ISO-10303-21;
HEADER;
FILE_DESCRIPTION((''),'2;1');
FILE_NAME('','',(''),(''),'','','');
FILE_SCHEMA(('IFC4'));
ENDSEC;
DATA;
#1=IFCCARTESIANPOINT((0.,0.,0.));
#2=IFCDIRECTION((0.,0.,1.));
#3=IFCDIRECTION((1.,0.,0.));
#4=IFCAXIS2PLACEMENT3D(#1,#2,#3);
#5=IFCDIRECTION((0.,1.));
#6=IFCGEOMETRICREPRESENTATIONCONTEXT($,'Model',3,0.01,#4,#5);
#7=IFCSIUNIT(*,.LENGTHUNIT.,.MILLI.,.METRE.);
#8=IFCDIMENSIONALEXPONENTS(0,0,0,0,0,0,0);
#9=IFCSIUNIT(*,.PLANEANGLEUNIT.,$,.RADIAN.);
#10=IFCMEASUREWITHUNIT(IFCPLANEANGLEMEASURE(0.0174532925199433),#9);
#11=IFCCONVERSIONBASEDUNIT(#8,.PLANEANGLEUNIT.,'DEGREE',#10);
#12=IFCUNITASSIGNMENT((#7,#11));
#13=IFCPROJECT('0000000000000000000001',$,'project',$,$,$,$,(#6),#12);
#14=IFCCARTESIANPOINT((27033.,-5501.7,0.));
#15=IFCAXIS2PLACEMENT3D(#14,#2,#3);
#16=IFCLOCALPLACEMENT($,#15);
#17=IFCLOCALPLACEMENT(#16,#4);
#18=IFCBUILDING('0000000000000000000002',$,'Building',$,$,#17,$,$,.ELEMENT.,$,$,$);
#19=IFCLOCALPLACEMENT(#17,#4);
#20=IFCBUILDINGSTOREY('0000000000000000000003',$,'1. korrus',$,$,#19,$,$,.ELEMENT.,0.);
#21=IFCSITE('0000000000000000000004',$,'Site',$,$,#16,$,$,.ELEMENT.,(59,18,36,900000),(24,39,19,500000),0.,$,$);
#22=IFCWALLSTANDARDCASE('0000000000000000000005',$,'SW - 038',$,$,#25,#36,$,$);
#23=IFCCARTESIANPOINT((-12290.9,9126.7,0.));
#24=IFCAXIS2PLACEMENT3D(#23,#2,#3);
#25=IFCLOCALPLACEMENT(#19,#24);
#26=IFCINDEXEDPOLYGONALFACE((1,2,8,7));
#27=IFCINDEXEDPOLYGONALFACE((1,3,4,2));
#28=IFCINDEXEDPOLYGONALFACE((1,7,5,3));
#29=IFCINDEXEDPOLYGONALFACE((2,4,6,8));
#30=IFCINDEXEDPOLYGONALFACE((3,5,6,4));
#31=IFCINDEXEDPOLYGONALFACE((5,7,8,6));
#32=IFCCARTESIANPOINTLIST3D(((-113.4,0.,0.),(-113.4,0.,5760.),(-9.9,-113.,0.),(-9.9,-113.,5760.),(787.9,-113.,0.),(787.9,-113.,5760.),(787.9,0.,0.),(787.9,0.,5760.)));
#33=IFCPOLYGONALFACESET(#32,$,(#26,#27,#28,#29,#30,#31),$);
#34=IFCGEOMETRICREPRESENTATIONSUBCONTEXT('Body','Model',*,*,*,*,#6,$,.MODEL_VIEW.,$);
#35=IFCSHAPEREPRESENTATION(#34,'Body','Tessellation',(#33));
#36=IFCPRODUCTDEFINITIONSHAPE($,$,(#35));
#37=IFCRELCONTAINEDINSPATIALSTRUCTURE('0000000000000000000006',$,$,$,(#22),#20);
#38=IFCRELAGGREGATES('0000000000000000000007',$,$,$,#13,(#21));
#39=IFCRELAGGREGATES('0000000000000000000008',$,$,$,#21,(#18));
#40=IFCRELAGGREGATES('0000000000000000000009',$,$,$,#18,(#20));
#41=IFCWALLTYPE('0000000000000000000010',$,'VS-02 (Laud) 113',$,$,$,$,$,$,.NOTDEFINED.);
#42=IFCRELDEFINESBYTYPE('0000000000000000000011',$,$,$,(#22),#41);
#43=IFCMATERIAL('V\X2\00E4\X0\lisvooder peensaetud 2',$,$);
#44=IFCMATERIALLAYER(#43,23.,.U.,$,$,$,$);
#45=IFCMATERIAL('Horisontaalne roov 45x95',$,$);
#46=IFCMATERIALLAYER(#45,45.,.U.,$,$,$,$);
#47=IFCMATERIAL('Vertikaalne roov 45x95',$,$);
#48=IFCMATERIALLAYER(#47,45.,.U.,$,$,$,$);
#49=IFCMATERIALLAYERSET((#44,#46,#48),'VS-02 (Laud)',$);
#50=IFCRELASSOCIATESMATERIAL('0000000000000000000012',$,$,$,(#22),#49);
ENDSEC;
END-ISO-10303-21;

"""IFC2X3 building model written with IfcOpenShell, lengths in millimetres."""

from ifc_helpers import new_model, entity, si_unit, converted_unit, direction, frame, origin_with_axes, place, context, subcontext, project, spatial, polyline, outline, extrude, material, layer, layer_set, layer_usage, type_object, element, save


model = new_model("IFC2X3")

# Units and contexts
model_context = context("Model", 3, precision=0.01, world=origin_with_axes(), true_north=direction((0.0, 1.0)))
body_context = subcontext(model_context, "Body", "Model", "MODEL_VIEW")
ifc_project = project(units=[si_unit("LENGTHUNIT", "METRE", prefix="MILLI"), converted_unit("PLANEANGLEUNIT", "DEGREE", entity("IfcPlaneAngleMeasure", 0.0174532925199433), si_unit("PLANEANGLEUNIT", "RADIAN"), dimensions=[0, 0, 0, 0, 0, 0, 0])], contexts=[model_context])

# Site, building, storey
site_placement = place(None, frame((27033.0, -5501.7, 0.0), z_axis=(0.0, 0.0, 1.0), x_axis=(1.0, 0.0, 0.0)))
site = spatial("IfcSite", under=ifc_project, at=site_placement, Name="Site", CompositionType="ELEMENT", RefLatitude=(59, 18, 36, 900000), RefLongitude=(24, 39, 19, 500000), RefElevation=0.0)
building_placement = place(site_placement, origin_with_axes())
building = spatial("IfcBuilding", under=site, at=building_placement, Name="Building", CompositionType="ELEMENT")
storey_placement = place(building_placement, origin_with_axes())
storey = spatial("IfcBuildingStorey", under=building, at=storey_placement, Name="1. korrus", CompositionType="ELEMENT", Elevation=0.0)

# Wall
ifc_material_1 = material(Name="Välisvooder peensaetud 2")
ifc_layer_1 = layer(ifc_material_1, 23.0, ventilated="UNKNOWN")
ifc_material_2 = material(Name="Horisontaalne roov 45x95")
ifc_layer_2 = layer(ifc_material_2, 45.0, ventilated="UNKNOWN")
ifc_material_3 = material(Name="Vertikaalne roov 45x95")
ifc_layer_3 = layer(ifc_material_3, 45.0, ventilated="UNKNOWN")
ifc_layer_set_1 = layer_set([ifc_layer_1, ifc_layer_2, ifc_layer_3], Name="VS-02 (Laud)")
ifc_layer_usage_1 = layer_usage(ifc_layer_set_1, "AXIS2", "POSITIVE", -113.0)
wall_type_1 = type_object("IfcWallType", Name="VS-02 (Laud) 113", PredefinedType="NOTDEFINED")
wall_1_placement = place(storey_placement, frame((-12290.9, 9126.7, 0.0), z_axis=(0.0, 0.0, 1.0), x_axis=(1.0, 0.0, 0.0)))
element("IfcWallStandardCase", 1, at=wall_1_placement, inside=storey, type_object=wall_type_1, material=ifc_layer_usage_1, Name="SW - 038", context=body_context, shape_type="SweptSolid", body=[
    extrude(outline(polyline([(-9.9, -113.0), (787.9, -113.0), (787.9, 0.0), (-113.4, 0.0), (-9.9, -113.0)])), origin_with_axes(), (0.0, 0.0, 1.0), 5760.0),
])

save(model, "model.ifc")
